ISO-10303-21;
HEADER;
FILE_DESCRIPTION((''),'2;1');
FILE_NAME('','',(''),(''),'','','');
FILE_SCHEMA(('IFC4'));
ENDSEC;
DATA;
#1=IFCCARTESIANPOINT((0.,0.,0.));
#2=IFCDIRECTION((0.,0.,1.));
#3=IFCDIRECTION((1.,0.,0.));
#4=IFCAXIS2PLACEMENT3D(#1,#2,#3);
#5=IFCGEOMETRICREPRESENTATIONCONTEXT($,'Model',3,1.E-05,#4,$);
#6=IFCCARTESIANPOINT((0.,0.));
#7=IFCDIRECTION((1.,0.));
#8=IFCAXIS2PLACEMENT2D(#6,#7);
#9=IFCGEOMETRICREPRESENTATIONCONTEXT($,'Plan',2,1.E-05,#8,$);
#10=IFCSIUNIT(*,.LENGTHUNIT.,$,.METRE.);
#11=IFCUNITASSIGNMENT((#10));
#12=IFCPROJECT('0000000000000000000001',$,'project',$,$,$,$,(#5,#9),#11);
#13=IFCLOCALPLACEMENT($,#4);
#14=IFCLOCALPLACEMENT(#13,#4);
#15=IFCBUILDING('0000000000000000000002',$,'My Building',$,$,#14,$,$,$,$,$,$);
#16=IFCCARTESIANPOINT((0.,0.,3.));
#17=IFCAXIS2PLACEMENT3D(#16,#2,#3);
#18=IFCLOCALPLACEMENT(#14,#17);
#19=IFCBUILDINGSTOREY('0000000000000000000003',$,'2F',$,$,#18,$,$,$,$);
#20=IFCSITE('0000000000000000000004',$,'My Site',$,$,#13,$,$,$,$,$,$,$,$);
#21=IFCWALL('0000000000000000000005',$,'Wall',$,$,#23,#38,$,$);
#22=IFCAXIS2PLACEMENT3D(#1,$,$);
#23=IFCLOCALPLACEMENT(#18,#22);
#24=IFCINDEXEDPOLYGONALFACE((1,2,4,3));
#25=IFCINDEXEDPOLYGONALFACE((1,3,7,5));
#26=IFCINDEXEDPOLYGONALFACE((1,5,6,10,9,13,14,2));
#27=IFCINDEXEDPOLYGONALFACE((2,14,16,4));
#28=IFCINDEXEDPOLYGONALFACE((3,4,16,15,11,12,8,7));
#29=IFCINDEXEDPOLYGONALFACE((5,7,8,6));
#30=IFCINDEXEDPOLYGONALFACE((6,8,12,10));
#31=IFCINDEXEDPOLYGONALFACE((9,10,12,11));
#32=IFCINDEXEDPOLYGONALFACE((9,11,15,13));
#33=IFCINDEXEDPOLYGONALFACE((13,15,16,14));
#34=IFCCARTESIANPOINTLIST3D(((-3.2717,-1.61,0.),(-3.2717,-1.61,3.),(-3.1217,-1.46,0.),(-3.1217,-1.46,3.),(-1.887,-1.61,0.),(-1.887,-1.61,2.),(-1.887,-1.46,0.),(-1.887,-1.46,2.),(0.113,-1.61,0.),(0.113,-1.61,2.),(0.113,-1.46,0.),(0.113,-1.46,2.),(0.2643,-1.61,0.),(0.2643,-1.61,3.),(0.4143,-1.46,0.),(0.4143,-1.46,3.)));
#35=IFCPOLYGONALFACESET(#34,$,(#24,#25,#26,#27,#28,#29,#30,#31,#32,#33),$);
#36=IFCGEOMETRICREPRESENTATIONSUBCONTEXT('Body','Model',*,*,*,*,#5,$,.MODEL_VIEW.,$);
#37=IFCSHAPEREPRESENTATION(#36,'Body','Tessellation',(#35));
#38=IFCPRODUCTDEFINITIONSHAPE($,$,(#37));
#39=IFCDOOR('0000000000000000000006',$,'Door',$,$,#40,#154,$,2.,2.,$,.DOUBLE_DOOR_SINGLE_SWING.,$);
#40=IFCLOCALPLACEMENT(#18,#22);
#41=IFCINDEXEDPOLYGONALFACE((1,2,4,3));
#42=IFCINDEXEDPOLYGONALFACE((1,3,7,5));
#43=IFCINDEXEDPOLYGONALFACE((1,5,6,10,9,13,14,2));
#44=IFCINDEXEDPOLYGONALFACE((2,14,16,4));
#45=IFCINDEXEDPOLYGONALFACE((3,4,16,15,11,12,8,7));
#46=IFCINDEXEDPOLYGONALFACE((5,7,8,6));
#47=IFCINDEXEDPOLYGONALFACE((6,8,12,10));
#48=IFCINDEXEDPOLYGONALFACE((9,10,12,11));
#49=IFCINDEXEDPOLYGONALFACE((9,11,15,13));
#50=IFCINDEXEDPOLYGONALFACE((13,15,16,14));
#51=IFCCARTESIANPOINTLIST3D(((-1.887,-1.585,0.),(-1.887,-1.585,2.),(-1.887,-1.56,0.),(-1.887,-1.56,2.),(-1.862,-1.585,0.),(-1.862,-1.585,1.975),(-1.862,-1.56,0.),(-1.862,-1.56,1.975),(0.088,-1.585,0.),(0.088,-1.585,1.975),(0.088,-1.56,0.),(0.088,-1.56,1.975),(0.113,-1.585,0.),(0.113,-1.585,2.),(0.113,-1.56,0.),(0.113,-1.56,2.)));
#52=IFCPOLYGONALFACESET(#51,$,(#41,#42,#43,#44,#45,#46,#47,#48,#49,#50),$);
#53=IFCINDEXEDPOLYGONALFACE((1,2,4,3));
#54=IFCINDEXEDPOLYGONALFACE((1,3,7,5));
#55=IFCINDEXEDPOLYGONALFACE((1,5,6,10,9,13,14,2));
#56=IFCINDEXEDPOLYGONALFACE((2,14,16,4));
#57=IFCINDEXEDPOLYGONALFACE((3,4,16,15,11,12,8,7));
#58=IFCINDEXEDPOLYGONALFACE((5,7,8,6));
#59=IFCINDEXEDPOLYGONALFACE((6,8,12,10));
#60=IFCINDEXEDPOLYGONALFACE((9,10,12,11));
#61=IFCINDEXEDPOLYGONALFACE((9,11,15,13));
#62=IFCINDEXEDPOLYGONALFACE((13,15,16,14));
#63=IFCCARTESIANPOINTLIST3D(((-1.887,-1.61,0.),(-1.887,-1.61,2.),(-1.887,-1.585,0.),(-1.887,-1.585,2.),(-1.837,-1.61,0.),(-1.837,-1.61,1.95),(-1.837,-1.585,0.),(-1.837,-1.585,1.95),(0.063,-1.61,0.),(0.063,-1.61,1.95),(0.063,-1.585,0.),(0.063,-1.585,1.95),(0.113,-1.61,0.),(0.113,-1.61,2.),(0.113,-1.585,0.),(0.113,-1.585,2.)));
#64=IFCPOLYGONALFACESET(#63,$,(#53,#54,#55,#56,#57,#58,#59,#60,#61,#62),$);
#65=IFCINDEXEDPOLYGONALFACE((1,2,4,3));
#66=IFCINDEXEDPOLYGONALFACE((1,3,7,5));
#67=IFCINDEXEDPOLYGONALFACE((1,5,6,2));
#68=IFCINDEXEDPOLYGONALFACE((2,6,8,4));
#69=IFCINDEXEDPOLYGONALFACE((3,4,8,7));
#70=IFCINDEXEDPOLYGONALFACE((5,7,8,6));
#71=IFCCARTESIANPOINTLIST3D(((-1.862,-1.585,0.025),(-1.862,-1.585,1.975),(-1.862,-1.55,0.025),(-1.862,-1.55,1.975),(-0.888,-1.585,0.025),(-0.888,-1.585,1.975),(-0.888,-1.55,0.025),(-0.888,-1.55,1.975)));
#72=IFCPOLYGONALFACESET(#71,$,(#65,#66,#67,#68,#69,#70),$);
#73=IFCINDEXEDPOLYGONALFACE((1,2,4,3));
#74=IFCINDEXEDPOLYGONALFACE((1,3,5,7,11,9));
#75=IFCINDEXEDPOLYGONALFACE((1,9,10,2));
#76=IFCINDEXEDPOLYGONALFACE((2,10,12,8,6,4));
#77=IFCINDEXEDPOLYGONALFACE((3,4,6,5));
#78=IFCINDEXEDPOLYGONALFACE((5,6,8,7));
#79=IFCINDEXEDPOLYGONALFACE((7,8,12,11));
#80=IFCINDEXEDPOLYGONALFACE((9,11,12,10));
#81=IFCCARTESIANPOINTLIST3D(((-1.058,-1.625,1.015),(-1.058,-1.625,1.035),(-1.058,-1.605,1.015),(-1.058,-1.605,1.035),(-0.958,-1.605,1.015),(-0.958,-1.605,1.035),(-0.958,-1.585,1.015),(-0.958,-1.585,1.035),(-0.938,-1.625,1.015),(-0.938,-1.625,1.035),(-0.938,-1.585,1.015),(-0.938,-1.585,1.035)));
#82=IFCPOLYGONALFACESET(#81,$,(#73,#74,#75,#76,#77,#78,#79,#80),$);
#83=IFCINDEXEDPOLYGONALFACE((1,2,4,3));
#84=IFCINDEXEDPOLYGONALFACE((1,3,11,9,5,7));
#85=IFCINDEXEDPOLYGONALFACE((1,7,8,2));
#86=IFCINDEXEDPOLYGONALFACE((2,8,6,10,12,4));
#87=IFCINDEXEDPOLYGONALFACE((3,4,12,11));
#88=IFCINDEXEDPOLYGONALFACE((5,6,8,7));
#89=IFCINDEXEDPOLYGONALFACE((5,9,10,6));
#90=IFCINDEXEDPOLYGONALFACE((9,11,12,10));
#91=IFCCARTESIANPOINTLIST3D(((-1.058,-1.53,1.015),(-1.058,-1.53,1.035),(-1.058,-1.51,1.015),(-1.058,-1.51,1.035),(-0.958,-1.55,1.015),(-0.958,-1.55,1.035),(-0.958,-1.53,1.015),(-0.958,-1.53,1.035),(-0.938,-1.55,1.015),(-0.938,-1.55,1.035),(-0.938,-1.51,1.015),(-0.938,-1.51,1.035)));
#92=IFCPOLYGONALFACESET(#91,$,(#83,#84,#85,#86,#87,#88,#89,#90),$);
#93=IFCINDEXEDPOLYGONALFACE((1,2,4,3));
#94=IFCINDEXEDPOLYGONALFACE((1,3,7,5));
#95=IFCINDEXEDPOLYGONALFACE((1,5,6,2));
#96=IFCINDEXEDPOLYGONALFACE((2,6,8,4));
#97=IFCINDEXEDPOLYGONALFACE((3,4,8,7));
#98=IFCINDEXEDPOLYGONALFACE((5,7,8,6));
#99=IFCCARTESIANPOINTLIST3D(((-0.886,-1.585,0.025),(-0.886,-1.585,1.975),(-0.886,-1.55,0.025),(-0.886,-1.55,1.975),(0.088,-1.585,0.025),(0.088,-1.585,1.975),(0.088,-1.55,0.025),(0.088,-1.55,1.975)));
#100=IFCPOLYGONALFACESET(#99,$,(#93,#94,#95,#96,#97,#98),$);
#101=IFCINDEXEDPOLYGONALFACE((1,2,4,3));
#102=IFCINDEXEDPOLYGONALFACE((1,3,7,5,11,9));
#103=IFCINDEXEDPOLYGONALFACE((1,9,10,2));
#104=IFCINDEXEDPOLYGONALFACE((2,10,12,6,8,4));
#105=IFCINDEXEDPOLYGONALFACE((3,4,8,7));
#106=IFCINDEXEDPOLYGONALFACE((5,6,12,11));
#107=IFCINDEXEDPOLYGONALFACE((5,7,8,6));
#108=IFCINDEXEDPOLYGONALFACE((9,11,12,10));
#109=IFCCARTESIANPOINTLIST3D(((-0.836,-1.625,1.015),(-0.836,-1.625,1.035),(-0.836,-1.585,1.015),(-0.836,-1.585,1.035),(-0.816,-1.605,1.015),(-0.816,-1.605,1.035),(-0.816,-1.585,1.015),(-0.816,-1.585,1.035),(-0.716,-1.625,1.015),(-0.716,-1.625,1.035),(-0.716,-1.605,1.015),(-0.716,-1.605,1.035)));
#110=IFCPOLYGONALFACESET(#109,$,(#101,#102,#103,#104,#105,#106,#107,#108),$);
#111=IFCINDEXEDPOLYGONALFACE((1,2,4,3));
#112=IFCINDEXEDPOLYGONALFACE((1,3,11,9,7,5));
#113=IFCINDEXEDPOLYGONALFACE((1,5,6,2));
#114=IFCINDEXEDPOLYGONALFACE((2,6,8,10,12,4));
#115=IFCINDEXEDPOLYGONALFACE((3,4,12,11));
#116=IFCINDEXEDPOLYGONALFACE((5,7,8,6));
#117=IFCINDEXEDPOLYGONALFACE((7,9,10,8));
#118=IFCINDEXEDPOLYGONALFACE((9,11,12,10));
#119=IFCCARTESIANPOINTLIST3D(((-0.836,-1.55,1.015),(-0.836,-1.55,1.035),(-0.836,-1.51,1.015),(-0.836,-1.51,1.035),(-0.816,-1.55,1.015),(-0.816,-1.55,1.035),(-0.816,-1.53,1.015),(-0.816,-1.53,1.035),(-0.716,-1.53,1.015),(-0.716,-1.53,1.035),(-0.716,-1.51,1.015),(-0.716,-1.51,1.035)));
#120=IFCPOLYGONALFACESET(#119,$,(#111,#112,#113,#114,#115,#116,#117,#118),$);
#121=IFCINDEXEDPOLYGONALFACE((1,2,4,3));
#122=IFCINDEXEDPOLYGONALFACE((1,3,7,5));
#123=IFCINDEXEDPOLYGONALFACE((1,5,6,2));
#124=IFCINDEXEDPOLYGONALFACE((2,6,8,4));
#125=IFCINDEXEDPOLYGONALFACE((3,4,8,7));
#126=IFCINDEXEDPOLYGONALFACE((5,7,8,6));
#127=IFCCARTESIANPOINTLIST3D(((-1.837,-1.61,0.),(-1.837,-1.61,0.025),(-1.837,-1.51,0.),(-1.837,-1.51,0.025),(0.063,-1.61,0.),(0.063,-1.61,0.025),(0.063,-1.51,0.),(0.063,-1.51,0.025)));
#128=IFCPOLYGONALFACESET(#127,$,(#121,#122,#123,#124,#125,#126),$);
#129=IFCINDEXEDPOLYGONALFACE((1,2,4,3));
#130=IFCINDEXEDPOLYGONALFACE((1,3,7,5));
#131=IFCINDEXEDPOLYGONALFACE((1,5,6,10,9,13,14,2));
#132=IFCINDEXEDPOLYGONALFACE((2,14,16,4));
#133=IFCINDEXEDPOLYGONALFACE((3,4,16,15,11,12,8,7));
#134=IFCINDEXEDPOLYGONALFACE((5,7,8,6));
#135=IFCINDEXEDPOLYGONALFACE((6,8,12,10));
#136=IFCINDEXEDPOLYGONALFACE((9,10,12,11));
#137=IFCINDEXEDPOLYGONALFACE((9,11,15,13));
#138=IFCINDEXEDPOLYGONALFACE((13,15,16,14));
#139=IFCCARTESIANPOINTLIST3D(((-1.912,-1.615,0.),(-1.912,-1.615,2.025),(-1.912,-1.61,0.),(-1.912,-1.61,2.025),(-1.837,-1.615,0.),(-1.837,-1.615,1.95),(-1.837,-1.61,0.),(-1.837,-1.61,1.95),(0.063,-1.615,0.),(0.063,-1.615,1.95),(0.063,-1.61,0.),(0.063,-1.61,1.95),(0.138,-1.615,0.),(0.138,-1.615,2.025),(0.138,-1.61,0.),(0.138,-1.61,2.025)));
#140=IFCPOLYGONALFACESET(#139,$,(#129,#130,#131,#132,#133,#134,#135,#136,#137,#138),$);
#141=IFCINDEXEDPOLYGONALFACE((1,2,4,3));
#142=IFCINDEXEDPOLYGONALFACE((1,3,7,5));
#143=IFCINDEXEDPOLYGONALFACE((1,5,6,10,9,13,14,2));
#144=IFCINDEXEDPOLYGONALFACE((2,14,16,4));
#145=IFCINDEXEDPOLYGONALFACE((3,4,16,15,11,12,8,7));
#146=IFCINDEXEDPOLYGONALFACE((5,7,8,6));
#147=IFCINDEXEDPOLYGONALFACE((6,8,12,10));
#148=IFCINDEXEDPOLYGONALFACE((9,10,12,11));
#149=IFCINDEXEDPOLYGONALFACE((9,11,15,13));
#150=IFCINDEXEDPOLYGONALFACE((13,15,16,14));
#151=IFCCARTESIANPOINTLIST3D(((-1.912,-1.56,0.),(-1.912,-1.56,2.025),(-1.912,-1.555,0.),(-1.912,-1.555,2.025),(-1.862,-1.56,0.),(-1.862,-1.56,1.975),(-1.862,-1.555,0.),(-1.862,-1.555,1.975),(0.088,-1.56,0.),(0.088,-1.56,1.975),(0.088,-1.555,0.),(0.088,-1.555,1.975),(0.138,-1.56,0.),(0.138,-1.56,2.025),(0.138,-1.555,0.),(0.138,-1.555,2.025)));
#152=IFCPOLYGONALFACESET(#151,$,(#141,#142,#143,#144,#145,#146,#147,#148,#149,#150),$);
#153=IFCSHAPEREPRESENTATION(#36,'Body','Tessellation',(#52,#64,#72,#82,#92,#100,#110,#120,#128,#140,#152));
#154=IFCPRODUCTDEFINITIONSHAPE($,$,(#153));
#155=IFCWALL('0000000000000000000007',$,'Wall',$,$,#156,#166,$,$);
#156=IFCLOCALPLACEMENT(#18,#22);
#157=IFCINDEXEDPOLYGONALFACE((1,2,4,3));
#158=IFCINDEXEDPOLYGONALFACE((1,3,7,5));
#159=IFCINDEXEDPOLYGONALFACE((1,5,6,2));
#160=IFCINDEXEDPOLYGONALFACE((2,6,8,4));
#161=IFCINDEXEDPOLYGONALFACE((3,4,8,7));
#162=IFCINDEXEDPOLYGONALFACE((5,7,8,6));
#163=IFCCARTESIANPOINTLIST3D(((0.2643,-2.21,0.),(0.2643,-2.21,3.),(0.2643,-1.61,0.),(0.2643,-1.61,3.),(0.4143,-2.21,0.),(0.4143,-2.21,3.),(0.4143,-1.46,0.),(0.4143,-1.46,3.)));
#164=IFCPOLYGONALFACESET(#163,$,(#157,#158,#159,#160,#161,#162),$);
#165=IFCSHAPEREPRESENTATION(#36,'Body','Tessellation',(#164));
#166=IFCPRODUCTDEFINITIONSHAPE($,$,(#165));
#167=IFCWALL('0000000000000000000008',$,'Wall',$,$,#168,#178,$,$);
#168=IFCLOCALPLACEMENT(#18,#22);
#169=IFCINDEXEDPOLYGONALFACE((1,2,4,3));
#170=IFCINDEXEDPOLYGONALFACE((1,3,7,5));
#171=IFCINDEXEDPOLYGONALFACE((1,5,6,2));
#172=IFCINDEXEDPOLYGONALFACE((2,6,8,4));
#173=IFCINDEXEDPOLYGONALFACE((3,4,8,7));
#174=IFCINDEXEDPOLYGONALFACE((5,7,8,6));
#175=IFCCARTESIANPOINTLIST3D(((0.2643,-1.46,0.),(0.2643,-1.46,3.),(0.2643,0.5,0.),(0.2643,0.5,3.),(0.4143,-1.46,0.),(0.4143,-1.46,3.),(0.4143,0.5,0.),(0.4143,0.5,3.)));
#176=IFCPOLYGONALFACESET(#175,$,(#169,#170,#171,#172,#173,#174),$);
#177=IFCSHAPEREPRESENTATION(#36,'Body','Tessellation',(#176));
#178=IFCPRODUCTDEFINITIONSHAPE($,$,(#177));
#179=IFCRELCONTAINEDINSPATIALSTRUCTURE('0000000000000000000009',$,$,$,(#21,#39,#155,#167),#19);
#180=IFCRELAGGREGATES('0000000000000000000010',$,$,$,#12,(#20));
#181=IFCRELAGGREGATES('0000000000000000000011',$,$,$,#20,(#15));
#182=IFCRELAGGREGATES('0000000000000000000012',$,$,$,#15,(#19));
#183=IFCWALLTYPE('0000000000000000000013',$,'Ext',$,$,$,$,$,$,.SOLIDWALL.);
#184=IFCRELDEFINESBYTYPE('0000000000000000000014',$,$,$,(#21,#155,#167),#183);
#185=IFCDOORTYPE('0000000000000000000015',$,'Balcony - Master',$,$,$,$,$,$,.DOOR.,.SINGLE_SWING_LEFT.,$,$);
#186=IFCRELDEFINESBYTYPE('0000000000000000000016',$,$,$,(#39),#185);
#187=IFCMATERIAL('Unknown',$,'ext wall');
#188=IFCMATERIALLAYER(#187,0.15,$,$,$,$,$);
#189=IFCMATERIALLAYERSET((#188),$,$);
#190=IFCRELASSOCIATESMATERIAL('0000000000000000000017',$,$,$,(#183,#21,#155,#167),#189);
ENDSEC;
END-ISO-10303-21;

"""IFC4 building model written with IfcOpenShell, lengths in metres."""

from ifc_helpers import new_model, entity, si_unit, frame, origin_with_axes, origin_2d_with_axis, place, context, subcontext, project, spatial, line, indexed_curve, outline, extrude, shape, source, transform, mapped, material, layer, layer_set, layer_usage, type_object, type_shapes, element, fill, save


model = new_model("IFC4")

# Units and contexts
model_context = context("Model", 3, precision=1e-05, world=origin_with_axes())
plan_context = context("Plan", 2, precision=1e-05, world=origin_2d_with_axis())
body_context_1 = subcontext(model_context, "Body", "Model", "MODEL_VIEW")
body_context_2 = subcontext(plan_context, "Body", "Plan", "PLAN_VIEW")
ifc_project = project(units=[si_unit("LENGTHUNIT", "METRE")], contexts=[model_context, plan_context])

# Site, building, storey
site_placement = place(None, origin_with_axes())
site = spatial("IfcSite", under=ifc_project, at=site_placement, Name="My Site")
building_placement = place(site_placement, origin_with_axes())
building = spatial("IfcBuilding", under=site, at=building_placement, Name="My Building")
storey_placement = place(building_placement, frame((0.0, 0.0, 3.0), z_axis=(0.0, 0.0, 1.0), x_axis=(1.0, 0.0, 0.0)))
storey = spatial("IfcBuildingStorey", under=building, at=storey_placement, Name="2F")

# Shared definitions
ifc_material = material(Name="Unknown", Category="ext wall")
ifc_layer_1 = layer(ifc_material, 0.15)
ifc_layer_set_1 = layer_set([ifc_layer_1])
wall_type_1 = type_object("IfcWallType", Name="Ext", PredefinedType="SOLIDWALL", material=ifc_layer_set_1)

# Wall, opening, door
ifc_layer_usage_1 = layer_usage(ifc_layer_set_1, "AXIS2", "POSITIVE", 0.0)
wall_1_placement = place(storey_placement, frame((-3.2717, -1.61, 0.0), z_axis=(0.0, 0.0, 1.0), x_axis=(1.0, 0.0, 0.0)))
wall_1 = element("IfcWall", 1, at=wall_1_placement, inside=storey, type_object=wall_type_1, material=ifc_layer_usage_1, Name="Wall", context=body_context_1, shape_type="SweptSolid", body=[
    extrude(outline(indexed_curve([(0.0, 0.0), (0.15, 0.15), (3.686, 0.15), (3.536, 0.0)], segments=[line(1, 2, 3, 4, 1)])), origin_with_axes(), (0.0, 0.0, 1.0), 3.0),
])
shared_shape_1 = source(origin_with_axes(), body_context_1, "Body", "SweptSolid", [
    extrude(outline(indexed_curve([(0.0, 0.0), (2.0, 0.0), (2.0, 2.0), (0.0, 2.0)], segments=[line(1, 2, 3, 4, 1)])), frame((0.0, -0.6, 0.0), z_axis=(0.0, -1.0, 0.0), x_axis=(1.0, 0.0, 0.0)), (0.0, 0.0, -1.0), 1.2),
])
opening_1_placement = place(wall_1_placement, frame((1.3847, 0.0, 0.0), z_axis=(0.0, 0.0, 1.0), x_axis=(1.0, 0.0, 0.0)))
opening_1 = element("IfcOpeningElement", 2, at=opening_1_placement, cuts=wall_1, PredefinedType="OPENING", context=body_context_1, shape_type="MappedRepresentation", body=[
    mapped(shared_shape_1, transform((0.0, 0.0, 0.0), x_axis=(1.0, 0.0, 0.0), y_axis=(0.0, 1.0, 0.0), z_axis=(0.0, 0.0, 1.0), scale=1.0)),
])
door_type_1 = type_object("IfcDoorType", Name="Balcony - Master", OperationType="SINGLE_SWING_LEFT", PredefinedType="DOOR")
shared_shape_2 = source(origin_with_axes(), body_context_1, "Body", "SweptSolid", [
    extrude(outline(indexed_curve([(0.0, 0.0), (0.0, 2.0), (2.0, 2.0), (2.0, 0.0), (1.975, 0.0), (1.975, 1.975), (0.025, 1.975), (0.025, 0.0)], segments=[line(1, 2, 3, 4, 5, 6, 7, 8, 1)])), frame((0.0, 0.025, 0.0), z_axis=(0.0, -1.0, 0.0), x_axis=(1.0, 0.0, 0.0)), (0.0, 0.0, -1.0), 0.025),
    extrude(outline(indexed_curve([(0.0, 0.0), (0.0, 2.0), (2.0, 2.0), (2.0, 0.0), (1.95, 0.0), (1.95, 1.95), (0.05, 1.95), (0.05, 0.0)], segments=[line(1, 2, 3, 4, 5, 6, 7, 8, 1)])), frame((0.0, 0.0, 0.0), z_axis=(0.0, -1.0, 0.0), x_axis=(1.0, 0.0, 0.0)), (0.0, 0.0, -1.0), 0.025),
    extrude(outline(indexed_curve([(0.0, 0.0), (0.974, 0.0), (0.974, 0.035), (0.0, 0.035)], segments=[line(1, 2, 3, 4, 1)])), frame((0.025, 0.025, 0.025), z_axis=(0.0, 0.0, 1.0), x_axis=(1.0, 0.0, 0.0)), (0.0, 0.0, 1.0), 1.95),
    extrude(outline(indexed_curve([(0.0, 0.0), (0.0, -0.04), (-0.12, -0.04), (-0.12, -0.02), (-0.02, -0.02), (-0.02, 0.0)], segments=[line(1, 2, 3, 4, 5, 6, 1)])), frame((0.949, 0.025, 1.015), z_axis=(0.0, 0.0, 1.0), x_axis=(1.0, 0.0, 0.0)), (0.0, 0.0, 1.0), 0.02),
    extrude(outline(indexed_curve([(0.0, 0.0), (0.0, 0.04), (-0.12, 0.04), (-0.12, 0.02), (-0.02, 0.02), (-0.02, 0.0)], segments=[line(1, 2, 3, 4, 5, 6, 1)])), frame((0.949, 0.06, 1.015), z_axis=(0.0, 0.0, 1.0), x_axis=(1.0, 0.0, 0.0)), (0.0, 0.0, 1.0), 0.02),
    extrude(outline(indexed_curve([(0.0, 0.0), (-0.974, 0.0), (-0.974, 0.035), (0.0, 0.035)], segments=[line(1, 2, 3, 4, 1)])), frame((1.975, 0.025, 0.025), z_axis=(0.0, 0.0, 1.0), x_axis=(1.0, 0.0, 0.0)), (0.0, 0.0, 1.0), 1.95),
    extrude(outline(indexed_curve([(0.0, 0.0), (0.0, -0.04), (0.12, -0.04), (0.12, -0.02), (0.02, -0.02), (0.02, 0.0)], segments=[line(1, 2, 3, 4, 5, 6, 1)])), frame((1.051, 0.025, 1.015), z_axis=(0.0, 0.0, 1.0), x_axis=(1.0, 0.0, 0.0)), (0.0, 0.0, 1.0), 0.02),
    extrude(outline(indexed_curve([(0.0, 0.0), (0.0, 0.04), (0.12, 0.04), (0.12, 0.02), (0.02, 0.02), (0.02, 0.0)], segments=[line(1, 2, 3, 4, 5, 6, 1)])), frame((1.051, 0.06, 1.015), z_axis=(0.0, 0.0, 1.0), x_axis=(1.0, 0.0, 0.0)), (0.0, 0.0, 1.0), 0.02),
    extrude(outline(indexed_curve([(0.0, 0.0), (1.9, 0.0), (1.9, 0.1), (0.0, 0.1)], segments=[line(1, 2, 3, 4, 1)])), frame((0.05, 0.0, 0.0), z_axis=(0.0, 0.0, 1.0), x_axis=(1.0, 0.0, 0.0)), (0.0, 0.0, 1.0), 0.025),
    extrude(outline(indexed_curve([(0.0, 0.0), (0.0, 2.025), (2.05, 2.025), (2.05, 0.0), (1.975, 0.0), (1.975, 1.95), (0.075, 1.95), (0.075, 0.0)], segments=[line(1, 2, 3, 4, 5, 6, 7, 8, 1)])), frame((-0.025, -0.005, 0.0), z_axis=(0.0, -1.0, 0.0), x_axis=(1.0, 0.0, 0.0)), (0.0, 0.0, -1.0), 0.005),
    extrude(outline(indexed_curve([(0.0, 0.0), (0.0, 2.025), (2.05, 2.025), (2.05, 0.0), (2.0, 0.0), (2.0, 1.975), (0.05, 1.975), (0.05, 0.0)], segments=[line(1, 2, 3, 4, 5, 6, 7, 8, 1)])), frame((-0.025, 0.05, 0.0), z_axis=(0.0, -1.0, 0.0), x_axis=(1.0, 0.0, 0.0)), (0.0, 0.0, -1.0), 0.005),
])
shared_shape_3 = source(origin_with_axes(), body_context_2, "Body", "Curve2D", [
    entity("IfcIndexedPolyCurve", entity("IfcCartesianPointList2D", [[0.0, 0.0], [0.0, 0.05], [0.025, 0.05], [0.025, 0.025], [0.05, 0.025], [0.05, 0.0]]), [entity("IfcLineIndex", [1, 2, 3, 4, 5, 6, 1])]),
    entity("IfcIndexedPolyCurve", entity("IfcCartesianPointList2D", [[2.0, 0.0], [2.0, 0.05], [1.975, 0.05], [1.975, 0.025], [1.95, 0.025], [1.95, 0.0]]), [entity("IfcLineIndex", [1, 2, 3, 4, 5, 6, 1])]),
    entity("IfcTrimmedCurve", entity("IfcEllipse", entity("IfcAxis2Placement2D", entity("IfcCartesianPoint", [0.06, 0.05]), entity("IfcDirection", [1.0, 0.0])), 0.94, 0.975), [entity("IfcCartesianPoint", [1.0, 0.05])], [entity("IfcCartesianPoint", [0.06, 1.025])], True, "CARTESIAN"),
    entity("IfcIndexedPolyCurve", entity("IfcCartesianPointList2D", [[0.025, 0.05], [0.06, 0.05], [0.06, 1.025], [0.025, 1.025]]), [entity("IfcLineIndex", [1, 2, 3, 4, 1])]),
    entity("IfcTrimmedCurve", entity("IfcEllipse", entity("IfcAxis2Placement2D", entity("IfcCartesianPoint", [1.94, 0.05]), entity("IfcDirection", [1.0, 0.0])), 0.94, 0.975), [entity("IfcCartesianPoint", [1.94, 1.025])], [entity("IfcCartesianPoint", [1.0, 0.05])], True, "CARTESIAN"),
    entity("IfcIndexedPolyCurve", entity("IfcCartesianPointList2D", [[1.975, 0.05], [1.94, 0.05], [1.94, 1.025], [1.975, 1.025]]), [entity("IfcLineIndex", [1, 2, 3, 4, 1])]),
])
type_shapes(door_type_1, [shared_shape_2, shared_shape_3])
door_1_placement = place(opening_1_placement, frame((0.0, 0.0, 0.0), z_axis=(0.0, 0.0, 1.0), x_axis=(1.0, 0.0, 0.0)))
door_1 = element("IfcDoor", 3, at=door_1_placement, inside=storey, type_object=door_type_1, Name="Door", OperationType="DOUBLE_DOOR_SINGLE_SWING", OverallHeight=2.0, OverallWidth=2.0, shapes=[
    shape(body_context_1, "Body", "MappedRepresentation", [mapped(shared_shape_2, transform((0.0, 0.0, 0.0), x_axis=(1.0, 0.0, 0.0), y_axis=(0.0, 1.0, 0.0), z_axis=(0.0, 0.0, 1.0), scale=1.0))]),
    shape(body_context_2, "Body", "MappedRepresentation", [mapped(shared_shape_3, transform((0.0, 0.0, 0.0), x_axis=(1.0, 0.0, 0.0), y_axis=(0.0, 1.0, 0.0), z_axis=(0.0, 0.0, 1.0), scale=1.0))]),
])
fill(opening_1, door_1)

# Walls
ifc_layer_usage_2 = layer_usage(ifc_layer_set_1, "AXIS2", "POSITIVE", 0.0)
wall_2_placement = place(storey_placement, frame((0.2643, -1.61, 0.0), z_axis=(0.0, 0.0, 1.0), x_axis=(0.0, -1.0, 0.0)))
element("IfcWall", 4, at=wall_2_placement, inside=storey, type_object=wall_type_1, material=ifc_layer_usage_2, Name="Wall", context=body_context_1, shape_type="SweptSolid", body=[
    extrude(outline(indexed_curve([(0.0, 0.0), (-0.15, 0.15), (0.6, 0.15), (0.6, 0.0)], segments=[line(1, 2, 3, 4, 1)])), origin_with_axes(), (0.0, 0.0, 1.0), 3.0),
])
ifc_layer_usage_3 = layer_usage(ifc_layer_set_1, "AXIS2", "POSITIVE", 0.0)
wall_3_placement = place(storey_placement, frame((0.4143, -1.46, 0.0), z_axis=(0.0, 0.0, 1.0), x_axis=(0.0, 1.0, 0.0)))
element("IfcWall", 5, at=wall_3_placement, inside=storey, type_object=wall_type_1, material=ifc_layer_usage_3, Name="Wall", context=body_context_1, shape_type="SweptSolid", body=[
    extrude(outline(indexed_curve([(0.0, 0.0), (0.0, 0.15), (1.96, 0.15), (1.96, 0.0)], segments=[line(1, 2, 3, 4, 1)])), origin_with_axes(), (0.0, 0.0, 1.0), 3.0),
])

save(model, "model.ifc")
